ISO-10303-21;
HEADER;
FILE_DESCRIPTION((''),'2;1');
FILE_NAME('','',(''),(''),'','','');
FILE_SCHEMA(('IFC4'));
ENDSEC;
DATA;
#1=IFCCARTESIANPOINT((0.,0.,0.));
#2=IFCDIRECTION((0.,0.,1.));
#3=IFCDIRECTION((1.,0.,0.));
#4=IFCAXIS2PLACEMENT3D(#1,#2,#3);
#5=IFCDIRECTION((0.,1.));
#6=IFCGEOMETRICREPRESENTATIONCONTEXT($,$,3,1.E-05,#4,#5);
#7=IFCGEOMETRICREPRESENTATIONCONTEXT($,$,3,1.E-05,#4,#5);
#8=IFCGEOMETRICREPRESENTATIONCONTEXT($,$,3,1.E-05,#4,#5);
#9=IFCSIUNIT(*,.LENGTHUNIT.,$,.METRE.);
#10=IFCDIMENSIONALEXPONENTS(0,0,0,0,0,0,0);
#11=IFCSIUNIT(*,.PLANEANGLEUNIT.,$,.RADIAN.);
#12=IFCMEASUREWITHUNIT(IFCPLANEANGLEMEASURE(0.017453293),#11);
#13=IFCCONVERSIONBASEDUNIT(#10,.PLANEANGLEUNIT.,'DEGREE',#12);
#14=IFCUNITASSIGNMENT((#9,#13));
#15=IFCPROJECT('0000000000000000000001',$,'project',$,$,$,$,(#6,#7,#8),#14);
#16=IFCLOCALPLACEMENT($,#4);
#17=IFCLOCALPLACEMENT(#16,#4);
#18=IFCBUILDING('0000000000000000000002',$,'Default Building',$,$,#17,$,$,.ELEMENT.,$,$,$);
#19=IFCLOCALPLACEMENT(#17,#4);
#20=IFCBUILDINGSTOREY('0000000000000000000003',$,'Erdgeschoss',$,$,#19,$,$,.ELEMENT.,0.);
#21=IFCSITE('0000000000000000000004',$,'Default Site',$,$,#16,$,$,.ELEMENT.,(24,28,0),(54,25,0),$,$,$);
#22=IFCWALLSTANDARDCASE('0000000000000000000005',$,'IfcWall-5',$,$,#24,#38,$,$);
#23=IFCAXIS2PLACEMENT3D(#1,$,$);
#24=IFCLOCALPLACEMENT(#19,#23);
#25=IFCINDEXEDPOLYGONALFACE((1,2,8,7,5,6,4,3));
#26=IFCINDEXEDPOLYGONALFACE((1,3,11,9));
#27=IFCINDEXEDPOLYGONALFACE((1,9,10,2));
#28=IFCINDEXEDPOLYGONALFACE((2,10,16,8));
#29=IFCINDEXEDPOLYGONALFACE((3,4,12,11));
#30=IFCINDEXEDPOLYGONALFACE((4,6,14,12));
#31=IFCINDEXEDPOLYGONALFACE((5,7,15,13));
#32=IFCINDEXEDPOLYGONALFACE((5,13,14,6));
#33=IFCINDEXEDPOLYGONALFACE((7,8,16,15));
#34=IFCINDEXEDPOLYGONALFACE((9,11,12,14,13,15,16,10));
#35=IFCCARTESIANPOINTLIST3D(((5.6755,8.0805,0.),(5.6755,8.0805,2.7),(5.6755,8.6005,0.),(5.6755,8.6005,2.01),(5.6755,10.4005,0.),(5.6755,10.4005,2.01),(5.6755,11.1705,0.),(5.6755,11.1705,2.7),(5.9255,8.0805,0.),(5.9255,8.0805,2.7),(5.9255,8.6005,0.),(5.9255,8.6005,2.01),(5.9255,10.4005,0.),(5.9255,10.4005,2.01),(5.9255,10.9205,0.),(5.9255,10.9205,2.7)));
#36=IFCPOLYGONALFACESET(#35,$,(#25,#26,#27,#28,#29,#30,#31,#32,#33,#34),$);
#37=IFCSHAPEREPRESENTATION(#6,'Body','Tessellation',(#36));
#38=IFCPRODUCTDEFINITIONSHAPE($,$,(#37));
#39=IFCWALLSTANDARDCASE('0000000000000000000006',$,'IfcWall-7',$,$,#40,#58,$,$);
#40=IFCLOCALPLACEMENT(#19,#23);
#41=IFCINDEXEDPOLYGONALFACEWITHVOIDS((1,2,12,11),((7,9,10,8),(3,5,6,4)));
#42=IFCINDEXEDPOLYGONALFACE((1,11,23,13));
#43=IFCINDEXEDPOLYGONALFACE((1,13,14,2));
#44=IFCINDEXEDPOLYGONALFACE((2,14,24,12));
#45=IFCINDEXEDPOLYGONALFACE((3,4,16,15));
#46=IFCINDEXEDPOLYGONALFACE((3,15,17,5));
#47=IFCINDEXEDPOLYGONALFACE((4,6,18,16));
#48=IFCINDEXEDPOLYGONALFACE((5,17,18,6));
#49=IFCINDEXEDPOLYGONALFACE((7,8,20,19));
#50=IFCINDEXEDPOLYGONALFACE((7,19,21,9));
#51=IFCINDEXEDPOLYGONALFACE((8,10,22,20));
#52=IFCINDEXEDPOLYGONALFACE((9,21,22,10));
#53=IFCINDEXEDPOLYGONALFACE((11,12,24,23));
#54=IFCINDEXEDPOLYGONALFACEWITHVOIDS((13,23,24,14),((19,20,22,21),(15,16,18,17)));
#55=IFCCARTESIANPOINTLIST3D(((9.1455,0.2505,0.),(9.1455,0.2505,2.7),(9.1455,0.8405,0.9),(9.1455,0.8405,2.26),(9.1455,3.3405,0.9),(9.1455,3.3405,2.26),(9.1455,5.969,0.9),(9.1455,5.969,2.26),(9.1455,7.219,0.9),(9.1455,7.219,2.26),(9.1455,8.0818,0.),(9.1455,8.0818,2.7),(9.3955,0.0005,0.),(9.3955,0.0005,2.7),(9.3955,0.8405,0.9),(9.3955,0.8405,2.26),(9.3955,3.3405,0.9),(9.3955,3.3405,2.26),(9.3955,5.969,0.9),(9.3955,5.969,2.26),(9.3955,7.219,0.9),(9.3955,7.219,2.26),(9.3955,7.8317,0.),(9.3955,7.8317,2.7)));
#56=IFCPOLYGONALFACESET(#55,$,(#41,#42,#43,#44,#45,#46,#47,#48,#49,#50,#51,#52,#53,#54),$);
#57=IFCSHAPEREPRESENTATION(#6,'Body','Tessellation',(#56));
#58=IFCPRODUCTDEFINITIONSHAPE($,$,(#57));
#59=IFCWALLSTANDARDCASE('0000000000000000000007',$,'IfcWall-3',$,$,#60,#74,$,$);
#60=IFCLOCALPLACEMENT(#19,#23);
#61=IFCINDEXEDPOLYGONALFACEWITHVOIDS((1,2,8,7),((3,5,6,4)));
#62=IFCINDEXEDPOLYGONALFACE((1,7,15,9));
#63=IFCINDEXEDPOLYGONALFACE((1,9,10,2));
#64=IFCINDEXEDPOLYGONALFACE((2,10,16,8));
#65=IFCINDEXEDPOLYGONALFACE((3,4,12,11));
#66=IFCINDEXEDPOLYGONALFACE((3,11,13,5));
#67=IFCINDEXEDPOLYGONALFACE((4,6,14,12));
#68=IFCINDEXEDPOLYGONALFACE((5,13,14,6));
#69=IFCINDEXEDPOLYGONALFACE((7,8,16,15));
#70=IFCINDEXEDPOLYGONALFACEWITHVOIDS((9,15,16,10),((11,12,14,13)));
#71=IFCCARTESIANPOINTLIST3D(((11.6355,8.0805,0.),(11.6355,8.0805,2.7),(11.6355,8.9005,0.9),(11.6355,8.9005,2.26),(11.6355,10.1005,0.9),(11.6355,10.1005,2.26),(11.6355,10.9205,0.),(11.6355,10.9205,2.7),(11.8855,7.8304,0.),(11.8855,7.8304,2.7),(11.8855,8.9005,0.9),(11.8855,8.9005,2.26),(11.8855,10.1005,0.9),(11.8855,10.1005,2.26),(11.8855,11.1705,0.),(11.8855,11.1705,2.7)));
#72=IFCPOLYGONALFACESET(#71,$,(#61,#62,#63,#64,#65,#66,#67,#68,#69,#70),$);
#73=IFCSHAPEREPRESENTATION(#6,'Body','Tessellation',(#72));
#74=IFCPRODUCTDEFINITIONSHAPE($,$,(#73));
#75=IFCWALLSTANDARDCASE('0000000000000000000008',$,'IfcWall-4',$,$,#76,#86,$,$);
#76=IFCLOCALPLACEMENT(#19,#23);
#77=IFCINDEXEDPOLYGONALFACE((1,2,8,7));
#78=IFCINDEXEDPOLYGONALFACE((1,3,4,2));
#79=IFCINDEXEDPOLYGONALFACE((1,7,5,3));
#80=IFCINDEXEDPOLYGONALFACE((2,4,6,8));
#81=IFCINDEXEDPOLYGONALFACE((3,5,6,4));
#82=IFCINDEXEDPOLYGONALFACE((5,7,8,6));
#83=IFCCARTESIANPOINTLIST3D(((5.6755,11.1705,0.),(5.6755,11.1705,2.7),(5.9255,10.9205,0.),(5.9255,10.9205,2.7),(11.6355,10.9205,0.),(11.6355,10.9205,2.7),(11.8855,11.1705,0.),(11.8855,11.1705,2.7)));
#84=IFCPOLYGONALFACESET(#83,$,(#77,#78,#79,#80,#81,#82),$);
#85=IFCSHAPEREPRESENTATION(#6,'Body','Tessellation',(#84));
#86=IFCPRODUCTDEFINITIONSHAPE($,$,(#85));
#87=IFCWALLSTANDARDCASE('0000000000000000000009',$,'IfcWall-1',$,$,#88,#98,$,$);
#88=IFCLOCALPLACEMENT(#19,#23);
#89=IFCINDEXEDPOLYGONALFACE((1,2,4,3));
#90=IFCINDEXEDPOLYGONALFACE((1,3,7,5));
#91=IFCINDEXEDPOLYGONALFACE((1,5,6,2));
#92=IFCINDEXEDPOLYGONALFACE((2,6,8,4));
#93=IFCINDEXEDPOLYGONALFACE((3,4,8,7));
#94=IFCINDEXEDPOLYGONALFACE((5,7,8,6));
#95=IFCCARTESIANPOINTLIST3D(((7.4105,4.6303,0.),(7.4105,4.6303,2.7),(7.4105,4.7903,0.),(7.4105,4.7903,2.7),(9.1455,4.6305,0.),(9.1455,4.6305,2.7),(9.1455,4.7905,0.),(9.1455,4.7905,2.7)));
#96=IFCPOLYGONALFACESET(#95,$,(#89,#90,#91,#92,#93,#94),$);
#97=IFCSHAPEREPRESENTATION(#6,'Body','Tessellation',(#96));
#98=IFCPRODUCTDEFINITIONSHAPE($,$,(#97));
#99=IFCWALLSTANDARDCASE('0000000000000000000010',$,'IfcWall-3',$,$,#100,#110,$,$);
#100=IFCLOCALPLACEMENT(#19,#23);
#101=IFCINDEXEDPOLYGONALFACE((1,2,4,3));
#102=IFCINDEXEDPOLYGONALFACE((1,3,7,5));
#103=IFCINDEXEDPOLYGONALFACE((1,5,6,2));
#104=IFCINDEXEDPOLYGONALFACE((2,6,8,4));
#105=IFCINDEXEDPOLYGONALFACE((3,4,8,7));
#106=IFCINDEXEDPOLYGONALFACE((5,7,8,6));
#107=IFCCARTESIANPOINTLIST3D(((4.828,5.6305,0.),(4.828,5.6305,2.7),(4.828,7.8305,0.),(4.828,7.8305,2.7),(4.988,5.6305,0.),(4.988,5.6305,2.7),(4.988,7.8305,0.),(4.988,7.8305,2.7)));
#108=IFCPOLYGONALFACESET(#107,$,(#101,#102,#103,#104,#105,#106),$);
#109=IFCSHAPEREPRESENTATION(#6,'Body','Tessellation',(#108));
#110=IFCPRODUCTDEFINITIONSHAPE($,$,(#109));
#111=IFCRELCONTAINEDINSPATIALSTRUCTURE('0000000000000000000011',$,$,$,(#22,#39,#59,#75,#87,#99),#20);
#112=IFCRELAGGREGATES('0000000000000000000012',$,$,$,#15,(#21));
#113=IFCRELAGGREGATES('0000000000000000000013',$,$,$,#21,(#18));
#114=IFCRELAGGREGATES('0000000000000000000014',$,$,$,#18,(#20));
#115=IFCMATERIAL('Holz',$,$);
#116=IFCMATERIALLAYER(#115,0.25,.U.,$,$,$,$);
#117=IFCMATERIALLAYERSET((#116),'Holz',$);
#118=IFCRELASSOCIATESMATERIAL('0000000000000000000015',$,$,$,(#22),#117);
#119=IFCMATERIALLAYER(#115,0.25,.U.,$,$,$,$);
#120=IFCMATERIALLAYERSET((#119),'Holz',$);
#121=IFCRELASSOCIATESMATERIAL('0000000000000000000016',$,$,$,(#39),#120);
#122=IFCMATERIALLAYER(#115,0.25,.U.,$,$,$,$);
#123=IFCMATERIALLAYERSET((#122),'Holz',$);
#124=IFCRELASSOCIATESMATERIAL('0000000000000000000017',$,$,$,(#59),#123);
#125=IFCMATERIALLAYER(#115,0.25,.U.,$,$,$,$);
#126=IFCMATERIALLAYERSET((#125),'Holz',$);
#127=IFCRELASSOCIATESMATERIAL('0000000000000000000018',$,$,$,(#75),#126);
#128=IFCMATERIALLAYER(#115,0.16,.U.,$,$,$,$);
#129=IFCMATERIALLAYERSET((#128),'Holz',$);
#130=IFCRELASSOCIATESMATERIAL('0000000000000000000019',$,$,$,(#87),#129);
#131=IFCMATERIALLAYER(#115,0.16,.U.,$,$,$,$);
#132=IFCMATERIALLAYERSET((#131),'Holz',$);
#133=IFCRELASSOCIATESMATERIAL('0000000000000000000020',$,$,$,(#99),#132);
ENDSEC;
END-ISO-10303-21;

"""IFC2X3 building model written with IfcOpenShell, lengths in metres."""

from ifc_helpers import new_model, entity, si_unit, converted_unit, direction, frame, frame_2d, origin_with_axes, place, context, project, spatial, polyline, rectangle, outline, extrude, material, layer, layer_set, layer_usage, element, save


model = new_model("IFC2X3")

# Units and contexts
context_of_model_1 = context(None, 3, precision=1e-05, world=origin_with_axes(), true_north=direction((0.0, 1.0)))
context_of_model_2 = context(None, 3, precision=1e-05, world=origin_with_axes(), true_north=direction((0.0, 1.0)))
context_of_model_3 = context(None, 3, precision=1e-05, world=origin_with_axes(), true_north=direction((0.0, 1.0)))
ifc_project = project(units=[si_unit("LENGTHUNIT", "METRE"), converted_unit("PLANEANGLEUNIT", "DEGREE", entity("IfcPlaneAngleMeasure", 0.017453293), si_unit("PLANEANGLEUNIT", "RADIAN"), dimensions=[0, 0, 0, 0, 0, 0, 0])], contexts=[context_of_model_1, context_of_model_2, context_of_model_3])

# Site, building, storey
site_placement = place(None, origin_with_axes())
site = spatial("IfcSite", under=ifc_project, at=site_placement, Name="Default Site", CompositionType="ELEMENT", RefLatitude=(24, 28, 0), RefLongitude=(54, 25, 0))
building_placement = place(site_placement, origin_with_axes())
building = spatial("IfcBuilding", under=site, at=building_placement, Name="Default Building", CompositionType="ELEMENT")
storey_placement = place(building_placement, origin_with_axes())
storey = spatial("IfcBuildingStorey", under=building, at=storey_placement, Name="Erdgeschoss", CompositionType="ELEMENT", Elevation=0.0)

# Shared definitions
ifc_material_1 = material(Name="Holz")

# Wall, opening
ifc_layer_1 = layer(ifc_material_1, 0.25, ventilated="UNKNOWN")
ifc_layer_set_1 = layer_set([ifc_layer_1], Name="Holz")
ifc_layer_usage_1 = layer_usage(ifc_layer_set_1, "AXIS2", "NEGATIVE", 0.0)
wall_1_placement = place(storey_placement, frame((5.9255, 10.9205, 0.0), z_axis=(0.0, 0.0, 1.0), x_axis=(0.0, -1.0, 0.0)))
wall_1 = element("IfcWallStandardCase", 1, at=wall_1_placement, inside=storey, material=ifc_layer_usage_1, Name="IfcWall-5", context=context_of_model_1, shape_type="SweptSolid", body=[
    extrude(outline(polyline([(-0.25, -0.25), (2.84, -0.25), (2.84, 0.0), (0.0, 0.0), (-0.25, -0.25)])), origin_with_axes(), (0.0, 0.0, 1.0), 2.7),
])
opening_1_placement = place(wall_1_placement, frame((1.42, -0.25, 0.0), z_axis=(0.0, 0.0, 1.0), x_axis=(1.0, 0.0, 0.0)))
element("IfcOpeningElement", 2, at=opening_1_placement, cuts=wall_1, context=context_of_model_1, shape_type="SweptSolid", body=[
    extrude(rectangle(XDim=2.01, YDim=1.8, at=frame_2d((0.0, 1.005), x_axis=(0.0, -1.0))), frame((0.0, 0.0, 0.0), z_axis=(0.0, 1.0, 0.0), x_axis=(-1.0, 0.0, 0.0)), (0.0, 0.0, 1.0), 0.25),
])

# Wall, openings
ifc_layer_2 = layer(ifc_material_1, 0.25, ventilated="UNKNOWN")
ifc_layer_set_2 = layer_set([ifc_layer_2], Name="Holz")
ifc_layer_usage_2 = layer_usage(ifc_layer_set_2, "AXIS2", "NEGATIVE", 0.0)
wall_2_placement = place(storey_placement, frame((9.3955, 8.0817, 0.0), z_axis=(0.0, 0.0, 1.0), x_axis=(0.0, -1.0, 0.0)))
wall_2 = element("IfcWallStandardCase", 3, at=wall_2_placement, inside=storey, material=ifc_layer_usage_2, Name="IfcWall-7", context=context_of_model_1, shape_type="SweptSolid", body=[
    extrude(outline(polyline([(-0.0001, -0.25), (7.8312, -0.25), (8.0812, 0.0), (0.25, 0.0), (-0.0001, -0.25)])), origin_with_axes(), (0.0, 0.0, 1.0), 2.7),
])
opening_2_placement = place(wall_2_placement, frame((5.9912, -0.25, 0.9), z_axis=(0.0, 0.0, 1.0), x_axis=(1.0, 0.0, 0.0)))
element("IfcOpeningElement", 4, at=opening_2_placement, cuts=wall_2, context=context_of_model_1, shape_type="SweptSolid", body=[
    extrude(rectangle(XDim=1.36, YDim=2.5, at=frame_2d((0.0, 0.68), x_axis=(0.0, -1.0))), frame((0.0, 0.0, 0.0), z_axis=(0.0, 1.0, 0.0), x_axis=(-1.0, 0.0, 0.0)), (0.0, 0.0, 1.0), 0.25),
])
opening_3_placement = place(wall_2_placement, frame((1.4877, -0.25, 0.9), z_axis=(0.0, 0.0, 1.0), x_axis=(1.0, 0.0, 0.0)))
element("IfcOpeningElement", 5, at=opening_3_placement, cuts=wall_2, context=context_of_model_1, shape_type="SweptSolid", body=[
    extrude(rectangle(XDim=1.36, YDim=1.25, at=frame_2d((0.0, 0.68), x_axis=(0.0, -1.0))), frame((0.0, 0.0, 0.0), z_axis=(0.0, 1.0, 0.0), x_axis=(-1.0, 0.0, 0.0)), (0.0, 0.0, 1.0), 0.25),
])

# Wall, opening
ifc_layer_3 = layer(ifc_material_1, 0.25, ventilated="UNKNOWN")
ifc_layer_set_3 = layer_set([ifc_layer_3], Name="Holz")
ifc_layer_usage_3 = layer_usage(ifc_layer_set_3, "AXIS2", "NEGATIVE", 0.0)
wall_3_placement = place(storey_placement, frame((11.6355, 8.0805, 0.0), z_axis=(0.0, 0.0, 1.0), x_axis=(0.0, 1.0, 0.0)))
wall_3 = element("IfcWallStandardCase", 6, at=wall_3_placement, inside=storey, material=ifc_layer_usage_3, Name="IfcWall-3", context=context_of_model_1, shape_type="SweptSolid", body=[
    extrude(outline(polyline([(-0.2501, -0.25), (3.09, -0.25), (2.84, 0.0), (0.0, 0.0), (-0.2501, -0.25)])), origin_with_axes(), (0.0, 0.0, 1.0), 2.7),
])
opening_4_placement = place(wall_3_placement, frame((1.42, -0.25, 0.9), z_axis=(0.0, 0.0, 1.0), x_axis=(1.0, 0.0, 0.0)))
element("IfcOpeningElement", 7, at=opening_4_placement, cuts=wall_3, context=context_of_model_1, shape_type="SweptSolid", body=[
    extrude(rectangle(XDim=1.36, YDim=1.2, at=frame_2d((0.0, 0.68), x_axis=(0.0, -1.0))), frame((0.0, 0.0, 0.0), z_axis=(0.0, 1.0, 0.0), x_axis=(-1.0, 0.0, 0.0)), (0.0, 0.0, 1.0), 0.25),
])

# Wall
ifc_layer_4 = layer(ifc_material_1, 0.25, ventilated="UNKNOWN")
ifc_layer_set_4 = layer_set([ifc_layer_4], Name="Holz")
ifc_layer_usage_4 = layer_usage(ifc_layer_set_4, "AXIS2", "NEGATIVE", 0.0)
wall_4_placement = place(storey_placement, frame((11.6355, 10.9205, 0.0), z_axis=(0.0, 0.0, 1.0), x_axis=(-1.0, 0.0, 0.0)))
element("IfcWallStandardCase", 8, at=wall_4_placement, inside=storey, material=ifc_layer_usage_4, Name="IfcWall-4", context=context_of_model_1, shape_type="SweptSolid", body=[
    extrude(outline(polyline([(-0.25, -0.25), (5.96, -0.25), (5.71, 0.0), (0.0, 0.0), (-0.25, -0.25)])), origin_with_axes(), (0.0, 0.0, 1.0), 2.7),
])

# Walls
ifc_layer_5 = layer(ifc_material_1, 0.16, ventilated="UNKNOWN")
ifc_layer_set_5 = layer_set([ifc_layer_5], Name="Holz")
ifc_layer_usage_5 = layer_usage(ifc_layer_set_5, "AXIS2", "NEGATIVE", 0.0)
wall_5_placement = place(storey_placement, frame((7.4105, 4.7903, 0.0), z_axis=(0.0, 0.0, 1.0), x_axis=(1.0, 0.000122, 0.0)))
element("IfcWallStandardCase", 9, at=wall_5_placement, inside=storey, material=ifc_layer_usage_5, Name="IfcWall-1", context=context_of_model_1, shape_type="SweptSolid", body=[
    extrude(outline(polyline([(0.0, -0.16), (1.735, -0.16), (1.735, 0.0), (0.0, 0.0), (0.0, -0.16)])), origin_with_axes(), (0.0, 0.0, 1.0), 2.7),
])
ifc_layer_6 = layer(ifc_material_1, 0.16, ventilated="UNKNOWN")
ifc_layer_set_6 = layer_set([ifc_layer_6], Name="Holz")
ifc_layer_usage_6 = layer_usage(ifc_layer_set_6, "AXIS2", "NEGATIVE", 0.0)
wall_6_placement = place(storey_placement, frame((4.828, 5.6305, 0.0), z_axis=(0.0, 0.0, 1.0), x_axis=(0.0, 1.0, 0.0)))
element("IfcWallStandardCase", 10, at=wall_6_placement, inside=storey, material=ifc_layer_usage_6, Name="IfcWall-3", context=context_of_model_1, shape_type="SweptSolid", body=[
    extrude(outline(polyline([(0.0, -0.16), (2.2, -0.16), (2.2, 0.0), (0.0, 0.0), (0.0, -0.16)])), origin_with_axes(), (0.0, 0.0, 1.0), 2.7),
])

save(model, "model.ifc")
